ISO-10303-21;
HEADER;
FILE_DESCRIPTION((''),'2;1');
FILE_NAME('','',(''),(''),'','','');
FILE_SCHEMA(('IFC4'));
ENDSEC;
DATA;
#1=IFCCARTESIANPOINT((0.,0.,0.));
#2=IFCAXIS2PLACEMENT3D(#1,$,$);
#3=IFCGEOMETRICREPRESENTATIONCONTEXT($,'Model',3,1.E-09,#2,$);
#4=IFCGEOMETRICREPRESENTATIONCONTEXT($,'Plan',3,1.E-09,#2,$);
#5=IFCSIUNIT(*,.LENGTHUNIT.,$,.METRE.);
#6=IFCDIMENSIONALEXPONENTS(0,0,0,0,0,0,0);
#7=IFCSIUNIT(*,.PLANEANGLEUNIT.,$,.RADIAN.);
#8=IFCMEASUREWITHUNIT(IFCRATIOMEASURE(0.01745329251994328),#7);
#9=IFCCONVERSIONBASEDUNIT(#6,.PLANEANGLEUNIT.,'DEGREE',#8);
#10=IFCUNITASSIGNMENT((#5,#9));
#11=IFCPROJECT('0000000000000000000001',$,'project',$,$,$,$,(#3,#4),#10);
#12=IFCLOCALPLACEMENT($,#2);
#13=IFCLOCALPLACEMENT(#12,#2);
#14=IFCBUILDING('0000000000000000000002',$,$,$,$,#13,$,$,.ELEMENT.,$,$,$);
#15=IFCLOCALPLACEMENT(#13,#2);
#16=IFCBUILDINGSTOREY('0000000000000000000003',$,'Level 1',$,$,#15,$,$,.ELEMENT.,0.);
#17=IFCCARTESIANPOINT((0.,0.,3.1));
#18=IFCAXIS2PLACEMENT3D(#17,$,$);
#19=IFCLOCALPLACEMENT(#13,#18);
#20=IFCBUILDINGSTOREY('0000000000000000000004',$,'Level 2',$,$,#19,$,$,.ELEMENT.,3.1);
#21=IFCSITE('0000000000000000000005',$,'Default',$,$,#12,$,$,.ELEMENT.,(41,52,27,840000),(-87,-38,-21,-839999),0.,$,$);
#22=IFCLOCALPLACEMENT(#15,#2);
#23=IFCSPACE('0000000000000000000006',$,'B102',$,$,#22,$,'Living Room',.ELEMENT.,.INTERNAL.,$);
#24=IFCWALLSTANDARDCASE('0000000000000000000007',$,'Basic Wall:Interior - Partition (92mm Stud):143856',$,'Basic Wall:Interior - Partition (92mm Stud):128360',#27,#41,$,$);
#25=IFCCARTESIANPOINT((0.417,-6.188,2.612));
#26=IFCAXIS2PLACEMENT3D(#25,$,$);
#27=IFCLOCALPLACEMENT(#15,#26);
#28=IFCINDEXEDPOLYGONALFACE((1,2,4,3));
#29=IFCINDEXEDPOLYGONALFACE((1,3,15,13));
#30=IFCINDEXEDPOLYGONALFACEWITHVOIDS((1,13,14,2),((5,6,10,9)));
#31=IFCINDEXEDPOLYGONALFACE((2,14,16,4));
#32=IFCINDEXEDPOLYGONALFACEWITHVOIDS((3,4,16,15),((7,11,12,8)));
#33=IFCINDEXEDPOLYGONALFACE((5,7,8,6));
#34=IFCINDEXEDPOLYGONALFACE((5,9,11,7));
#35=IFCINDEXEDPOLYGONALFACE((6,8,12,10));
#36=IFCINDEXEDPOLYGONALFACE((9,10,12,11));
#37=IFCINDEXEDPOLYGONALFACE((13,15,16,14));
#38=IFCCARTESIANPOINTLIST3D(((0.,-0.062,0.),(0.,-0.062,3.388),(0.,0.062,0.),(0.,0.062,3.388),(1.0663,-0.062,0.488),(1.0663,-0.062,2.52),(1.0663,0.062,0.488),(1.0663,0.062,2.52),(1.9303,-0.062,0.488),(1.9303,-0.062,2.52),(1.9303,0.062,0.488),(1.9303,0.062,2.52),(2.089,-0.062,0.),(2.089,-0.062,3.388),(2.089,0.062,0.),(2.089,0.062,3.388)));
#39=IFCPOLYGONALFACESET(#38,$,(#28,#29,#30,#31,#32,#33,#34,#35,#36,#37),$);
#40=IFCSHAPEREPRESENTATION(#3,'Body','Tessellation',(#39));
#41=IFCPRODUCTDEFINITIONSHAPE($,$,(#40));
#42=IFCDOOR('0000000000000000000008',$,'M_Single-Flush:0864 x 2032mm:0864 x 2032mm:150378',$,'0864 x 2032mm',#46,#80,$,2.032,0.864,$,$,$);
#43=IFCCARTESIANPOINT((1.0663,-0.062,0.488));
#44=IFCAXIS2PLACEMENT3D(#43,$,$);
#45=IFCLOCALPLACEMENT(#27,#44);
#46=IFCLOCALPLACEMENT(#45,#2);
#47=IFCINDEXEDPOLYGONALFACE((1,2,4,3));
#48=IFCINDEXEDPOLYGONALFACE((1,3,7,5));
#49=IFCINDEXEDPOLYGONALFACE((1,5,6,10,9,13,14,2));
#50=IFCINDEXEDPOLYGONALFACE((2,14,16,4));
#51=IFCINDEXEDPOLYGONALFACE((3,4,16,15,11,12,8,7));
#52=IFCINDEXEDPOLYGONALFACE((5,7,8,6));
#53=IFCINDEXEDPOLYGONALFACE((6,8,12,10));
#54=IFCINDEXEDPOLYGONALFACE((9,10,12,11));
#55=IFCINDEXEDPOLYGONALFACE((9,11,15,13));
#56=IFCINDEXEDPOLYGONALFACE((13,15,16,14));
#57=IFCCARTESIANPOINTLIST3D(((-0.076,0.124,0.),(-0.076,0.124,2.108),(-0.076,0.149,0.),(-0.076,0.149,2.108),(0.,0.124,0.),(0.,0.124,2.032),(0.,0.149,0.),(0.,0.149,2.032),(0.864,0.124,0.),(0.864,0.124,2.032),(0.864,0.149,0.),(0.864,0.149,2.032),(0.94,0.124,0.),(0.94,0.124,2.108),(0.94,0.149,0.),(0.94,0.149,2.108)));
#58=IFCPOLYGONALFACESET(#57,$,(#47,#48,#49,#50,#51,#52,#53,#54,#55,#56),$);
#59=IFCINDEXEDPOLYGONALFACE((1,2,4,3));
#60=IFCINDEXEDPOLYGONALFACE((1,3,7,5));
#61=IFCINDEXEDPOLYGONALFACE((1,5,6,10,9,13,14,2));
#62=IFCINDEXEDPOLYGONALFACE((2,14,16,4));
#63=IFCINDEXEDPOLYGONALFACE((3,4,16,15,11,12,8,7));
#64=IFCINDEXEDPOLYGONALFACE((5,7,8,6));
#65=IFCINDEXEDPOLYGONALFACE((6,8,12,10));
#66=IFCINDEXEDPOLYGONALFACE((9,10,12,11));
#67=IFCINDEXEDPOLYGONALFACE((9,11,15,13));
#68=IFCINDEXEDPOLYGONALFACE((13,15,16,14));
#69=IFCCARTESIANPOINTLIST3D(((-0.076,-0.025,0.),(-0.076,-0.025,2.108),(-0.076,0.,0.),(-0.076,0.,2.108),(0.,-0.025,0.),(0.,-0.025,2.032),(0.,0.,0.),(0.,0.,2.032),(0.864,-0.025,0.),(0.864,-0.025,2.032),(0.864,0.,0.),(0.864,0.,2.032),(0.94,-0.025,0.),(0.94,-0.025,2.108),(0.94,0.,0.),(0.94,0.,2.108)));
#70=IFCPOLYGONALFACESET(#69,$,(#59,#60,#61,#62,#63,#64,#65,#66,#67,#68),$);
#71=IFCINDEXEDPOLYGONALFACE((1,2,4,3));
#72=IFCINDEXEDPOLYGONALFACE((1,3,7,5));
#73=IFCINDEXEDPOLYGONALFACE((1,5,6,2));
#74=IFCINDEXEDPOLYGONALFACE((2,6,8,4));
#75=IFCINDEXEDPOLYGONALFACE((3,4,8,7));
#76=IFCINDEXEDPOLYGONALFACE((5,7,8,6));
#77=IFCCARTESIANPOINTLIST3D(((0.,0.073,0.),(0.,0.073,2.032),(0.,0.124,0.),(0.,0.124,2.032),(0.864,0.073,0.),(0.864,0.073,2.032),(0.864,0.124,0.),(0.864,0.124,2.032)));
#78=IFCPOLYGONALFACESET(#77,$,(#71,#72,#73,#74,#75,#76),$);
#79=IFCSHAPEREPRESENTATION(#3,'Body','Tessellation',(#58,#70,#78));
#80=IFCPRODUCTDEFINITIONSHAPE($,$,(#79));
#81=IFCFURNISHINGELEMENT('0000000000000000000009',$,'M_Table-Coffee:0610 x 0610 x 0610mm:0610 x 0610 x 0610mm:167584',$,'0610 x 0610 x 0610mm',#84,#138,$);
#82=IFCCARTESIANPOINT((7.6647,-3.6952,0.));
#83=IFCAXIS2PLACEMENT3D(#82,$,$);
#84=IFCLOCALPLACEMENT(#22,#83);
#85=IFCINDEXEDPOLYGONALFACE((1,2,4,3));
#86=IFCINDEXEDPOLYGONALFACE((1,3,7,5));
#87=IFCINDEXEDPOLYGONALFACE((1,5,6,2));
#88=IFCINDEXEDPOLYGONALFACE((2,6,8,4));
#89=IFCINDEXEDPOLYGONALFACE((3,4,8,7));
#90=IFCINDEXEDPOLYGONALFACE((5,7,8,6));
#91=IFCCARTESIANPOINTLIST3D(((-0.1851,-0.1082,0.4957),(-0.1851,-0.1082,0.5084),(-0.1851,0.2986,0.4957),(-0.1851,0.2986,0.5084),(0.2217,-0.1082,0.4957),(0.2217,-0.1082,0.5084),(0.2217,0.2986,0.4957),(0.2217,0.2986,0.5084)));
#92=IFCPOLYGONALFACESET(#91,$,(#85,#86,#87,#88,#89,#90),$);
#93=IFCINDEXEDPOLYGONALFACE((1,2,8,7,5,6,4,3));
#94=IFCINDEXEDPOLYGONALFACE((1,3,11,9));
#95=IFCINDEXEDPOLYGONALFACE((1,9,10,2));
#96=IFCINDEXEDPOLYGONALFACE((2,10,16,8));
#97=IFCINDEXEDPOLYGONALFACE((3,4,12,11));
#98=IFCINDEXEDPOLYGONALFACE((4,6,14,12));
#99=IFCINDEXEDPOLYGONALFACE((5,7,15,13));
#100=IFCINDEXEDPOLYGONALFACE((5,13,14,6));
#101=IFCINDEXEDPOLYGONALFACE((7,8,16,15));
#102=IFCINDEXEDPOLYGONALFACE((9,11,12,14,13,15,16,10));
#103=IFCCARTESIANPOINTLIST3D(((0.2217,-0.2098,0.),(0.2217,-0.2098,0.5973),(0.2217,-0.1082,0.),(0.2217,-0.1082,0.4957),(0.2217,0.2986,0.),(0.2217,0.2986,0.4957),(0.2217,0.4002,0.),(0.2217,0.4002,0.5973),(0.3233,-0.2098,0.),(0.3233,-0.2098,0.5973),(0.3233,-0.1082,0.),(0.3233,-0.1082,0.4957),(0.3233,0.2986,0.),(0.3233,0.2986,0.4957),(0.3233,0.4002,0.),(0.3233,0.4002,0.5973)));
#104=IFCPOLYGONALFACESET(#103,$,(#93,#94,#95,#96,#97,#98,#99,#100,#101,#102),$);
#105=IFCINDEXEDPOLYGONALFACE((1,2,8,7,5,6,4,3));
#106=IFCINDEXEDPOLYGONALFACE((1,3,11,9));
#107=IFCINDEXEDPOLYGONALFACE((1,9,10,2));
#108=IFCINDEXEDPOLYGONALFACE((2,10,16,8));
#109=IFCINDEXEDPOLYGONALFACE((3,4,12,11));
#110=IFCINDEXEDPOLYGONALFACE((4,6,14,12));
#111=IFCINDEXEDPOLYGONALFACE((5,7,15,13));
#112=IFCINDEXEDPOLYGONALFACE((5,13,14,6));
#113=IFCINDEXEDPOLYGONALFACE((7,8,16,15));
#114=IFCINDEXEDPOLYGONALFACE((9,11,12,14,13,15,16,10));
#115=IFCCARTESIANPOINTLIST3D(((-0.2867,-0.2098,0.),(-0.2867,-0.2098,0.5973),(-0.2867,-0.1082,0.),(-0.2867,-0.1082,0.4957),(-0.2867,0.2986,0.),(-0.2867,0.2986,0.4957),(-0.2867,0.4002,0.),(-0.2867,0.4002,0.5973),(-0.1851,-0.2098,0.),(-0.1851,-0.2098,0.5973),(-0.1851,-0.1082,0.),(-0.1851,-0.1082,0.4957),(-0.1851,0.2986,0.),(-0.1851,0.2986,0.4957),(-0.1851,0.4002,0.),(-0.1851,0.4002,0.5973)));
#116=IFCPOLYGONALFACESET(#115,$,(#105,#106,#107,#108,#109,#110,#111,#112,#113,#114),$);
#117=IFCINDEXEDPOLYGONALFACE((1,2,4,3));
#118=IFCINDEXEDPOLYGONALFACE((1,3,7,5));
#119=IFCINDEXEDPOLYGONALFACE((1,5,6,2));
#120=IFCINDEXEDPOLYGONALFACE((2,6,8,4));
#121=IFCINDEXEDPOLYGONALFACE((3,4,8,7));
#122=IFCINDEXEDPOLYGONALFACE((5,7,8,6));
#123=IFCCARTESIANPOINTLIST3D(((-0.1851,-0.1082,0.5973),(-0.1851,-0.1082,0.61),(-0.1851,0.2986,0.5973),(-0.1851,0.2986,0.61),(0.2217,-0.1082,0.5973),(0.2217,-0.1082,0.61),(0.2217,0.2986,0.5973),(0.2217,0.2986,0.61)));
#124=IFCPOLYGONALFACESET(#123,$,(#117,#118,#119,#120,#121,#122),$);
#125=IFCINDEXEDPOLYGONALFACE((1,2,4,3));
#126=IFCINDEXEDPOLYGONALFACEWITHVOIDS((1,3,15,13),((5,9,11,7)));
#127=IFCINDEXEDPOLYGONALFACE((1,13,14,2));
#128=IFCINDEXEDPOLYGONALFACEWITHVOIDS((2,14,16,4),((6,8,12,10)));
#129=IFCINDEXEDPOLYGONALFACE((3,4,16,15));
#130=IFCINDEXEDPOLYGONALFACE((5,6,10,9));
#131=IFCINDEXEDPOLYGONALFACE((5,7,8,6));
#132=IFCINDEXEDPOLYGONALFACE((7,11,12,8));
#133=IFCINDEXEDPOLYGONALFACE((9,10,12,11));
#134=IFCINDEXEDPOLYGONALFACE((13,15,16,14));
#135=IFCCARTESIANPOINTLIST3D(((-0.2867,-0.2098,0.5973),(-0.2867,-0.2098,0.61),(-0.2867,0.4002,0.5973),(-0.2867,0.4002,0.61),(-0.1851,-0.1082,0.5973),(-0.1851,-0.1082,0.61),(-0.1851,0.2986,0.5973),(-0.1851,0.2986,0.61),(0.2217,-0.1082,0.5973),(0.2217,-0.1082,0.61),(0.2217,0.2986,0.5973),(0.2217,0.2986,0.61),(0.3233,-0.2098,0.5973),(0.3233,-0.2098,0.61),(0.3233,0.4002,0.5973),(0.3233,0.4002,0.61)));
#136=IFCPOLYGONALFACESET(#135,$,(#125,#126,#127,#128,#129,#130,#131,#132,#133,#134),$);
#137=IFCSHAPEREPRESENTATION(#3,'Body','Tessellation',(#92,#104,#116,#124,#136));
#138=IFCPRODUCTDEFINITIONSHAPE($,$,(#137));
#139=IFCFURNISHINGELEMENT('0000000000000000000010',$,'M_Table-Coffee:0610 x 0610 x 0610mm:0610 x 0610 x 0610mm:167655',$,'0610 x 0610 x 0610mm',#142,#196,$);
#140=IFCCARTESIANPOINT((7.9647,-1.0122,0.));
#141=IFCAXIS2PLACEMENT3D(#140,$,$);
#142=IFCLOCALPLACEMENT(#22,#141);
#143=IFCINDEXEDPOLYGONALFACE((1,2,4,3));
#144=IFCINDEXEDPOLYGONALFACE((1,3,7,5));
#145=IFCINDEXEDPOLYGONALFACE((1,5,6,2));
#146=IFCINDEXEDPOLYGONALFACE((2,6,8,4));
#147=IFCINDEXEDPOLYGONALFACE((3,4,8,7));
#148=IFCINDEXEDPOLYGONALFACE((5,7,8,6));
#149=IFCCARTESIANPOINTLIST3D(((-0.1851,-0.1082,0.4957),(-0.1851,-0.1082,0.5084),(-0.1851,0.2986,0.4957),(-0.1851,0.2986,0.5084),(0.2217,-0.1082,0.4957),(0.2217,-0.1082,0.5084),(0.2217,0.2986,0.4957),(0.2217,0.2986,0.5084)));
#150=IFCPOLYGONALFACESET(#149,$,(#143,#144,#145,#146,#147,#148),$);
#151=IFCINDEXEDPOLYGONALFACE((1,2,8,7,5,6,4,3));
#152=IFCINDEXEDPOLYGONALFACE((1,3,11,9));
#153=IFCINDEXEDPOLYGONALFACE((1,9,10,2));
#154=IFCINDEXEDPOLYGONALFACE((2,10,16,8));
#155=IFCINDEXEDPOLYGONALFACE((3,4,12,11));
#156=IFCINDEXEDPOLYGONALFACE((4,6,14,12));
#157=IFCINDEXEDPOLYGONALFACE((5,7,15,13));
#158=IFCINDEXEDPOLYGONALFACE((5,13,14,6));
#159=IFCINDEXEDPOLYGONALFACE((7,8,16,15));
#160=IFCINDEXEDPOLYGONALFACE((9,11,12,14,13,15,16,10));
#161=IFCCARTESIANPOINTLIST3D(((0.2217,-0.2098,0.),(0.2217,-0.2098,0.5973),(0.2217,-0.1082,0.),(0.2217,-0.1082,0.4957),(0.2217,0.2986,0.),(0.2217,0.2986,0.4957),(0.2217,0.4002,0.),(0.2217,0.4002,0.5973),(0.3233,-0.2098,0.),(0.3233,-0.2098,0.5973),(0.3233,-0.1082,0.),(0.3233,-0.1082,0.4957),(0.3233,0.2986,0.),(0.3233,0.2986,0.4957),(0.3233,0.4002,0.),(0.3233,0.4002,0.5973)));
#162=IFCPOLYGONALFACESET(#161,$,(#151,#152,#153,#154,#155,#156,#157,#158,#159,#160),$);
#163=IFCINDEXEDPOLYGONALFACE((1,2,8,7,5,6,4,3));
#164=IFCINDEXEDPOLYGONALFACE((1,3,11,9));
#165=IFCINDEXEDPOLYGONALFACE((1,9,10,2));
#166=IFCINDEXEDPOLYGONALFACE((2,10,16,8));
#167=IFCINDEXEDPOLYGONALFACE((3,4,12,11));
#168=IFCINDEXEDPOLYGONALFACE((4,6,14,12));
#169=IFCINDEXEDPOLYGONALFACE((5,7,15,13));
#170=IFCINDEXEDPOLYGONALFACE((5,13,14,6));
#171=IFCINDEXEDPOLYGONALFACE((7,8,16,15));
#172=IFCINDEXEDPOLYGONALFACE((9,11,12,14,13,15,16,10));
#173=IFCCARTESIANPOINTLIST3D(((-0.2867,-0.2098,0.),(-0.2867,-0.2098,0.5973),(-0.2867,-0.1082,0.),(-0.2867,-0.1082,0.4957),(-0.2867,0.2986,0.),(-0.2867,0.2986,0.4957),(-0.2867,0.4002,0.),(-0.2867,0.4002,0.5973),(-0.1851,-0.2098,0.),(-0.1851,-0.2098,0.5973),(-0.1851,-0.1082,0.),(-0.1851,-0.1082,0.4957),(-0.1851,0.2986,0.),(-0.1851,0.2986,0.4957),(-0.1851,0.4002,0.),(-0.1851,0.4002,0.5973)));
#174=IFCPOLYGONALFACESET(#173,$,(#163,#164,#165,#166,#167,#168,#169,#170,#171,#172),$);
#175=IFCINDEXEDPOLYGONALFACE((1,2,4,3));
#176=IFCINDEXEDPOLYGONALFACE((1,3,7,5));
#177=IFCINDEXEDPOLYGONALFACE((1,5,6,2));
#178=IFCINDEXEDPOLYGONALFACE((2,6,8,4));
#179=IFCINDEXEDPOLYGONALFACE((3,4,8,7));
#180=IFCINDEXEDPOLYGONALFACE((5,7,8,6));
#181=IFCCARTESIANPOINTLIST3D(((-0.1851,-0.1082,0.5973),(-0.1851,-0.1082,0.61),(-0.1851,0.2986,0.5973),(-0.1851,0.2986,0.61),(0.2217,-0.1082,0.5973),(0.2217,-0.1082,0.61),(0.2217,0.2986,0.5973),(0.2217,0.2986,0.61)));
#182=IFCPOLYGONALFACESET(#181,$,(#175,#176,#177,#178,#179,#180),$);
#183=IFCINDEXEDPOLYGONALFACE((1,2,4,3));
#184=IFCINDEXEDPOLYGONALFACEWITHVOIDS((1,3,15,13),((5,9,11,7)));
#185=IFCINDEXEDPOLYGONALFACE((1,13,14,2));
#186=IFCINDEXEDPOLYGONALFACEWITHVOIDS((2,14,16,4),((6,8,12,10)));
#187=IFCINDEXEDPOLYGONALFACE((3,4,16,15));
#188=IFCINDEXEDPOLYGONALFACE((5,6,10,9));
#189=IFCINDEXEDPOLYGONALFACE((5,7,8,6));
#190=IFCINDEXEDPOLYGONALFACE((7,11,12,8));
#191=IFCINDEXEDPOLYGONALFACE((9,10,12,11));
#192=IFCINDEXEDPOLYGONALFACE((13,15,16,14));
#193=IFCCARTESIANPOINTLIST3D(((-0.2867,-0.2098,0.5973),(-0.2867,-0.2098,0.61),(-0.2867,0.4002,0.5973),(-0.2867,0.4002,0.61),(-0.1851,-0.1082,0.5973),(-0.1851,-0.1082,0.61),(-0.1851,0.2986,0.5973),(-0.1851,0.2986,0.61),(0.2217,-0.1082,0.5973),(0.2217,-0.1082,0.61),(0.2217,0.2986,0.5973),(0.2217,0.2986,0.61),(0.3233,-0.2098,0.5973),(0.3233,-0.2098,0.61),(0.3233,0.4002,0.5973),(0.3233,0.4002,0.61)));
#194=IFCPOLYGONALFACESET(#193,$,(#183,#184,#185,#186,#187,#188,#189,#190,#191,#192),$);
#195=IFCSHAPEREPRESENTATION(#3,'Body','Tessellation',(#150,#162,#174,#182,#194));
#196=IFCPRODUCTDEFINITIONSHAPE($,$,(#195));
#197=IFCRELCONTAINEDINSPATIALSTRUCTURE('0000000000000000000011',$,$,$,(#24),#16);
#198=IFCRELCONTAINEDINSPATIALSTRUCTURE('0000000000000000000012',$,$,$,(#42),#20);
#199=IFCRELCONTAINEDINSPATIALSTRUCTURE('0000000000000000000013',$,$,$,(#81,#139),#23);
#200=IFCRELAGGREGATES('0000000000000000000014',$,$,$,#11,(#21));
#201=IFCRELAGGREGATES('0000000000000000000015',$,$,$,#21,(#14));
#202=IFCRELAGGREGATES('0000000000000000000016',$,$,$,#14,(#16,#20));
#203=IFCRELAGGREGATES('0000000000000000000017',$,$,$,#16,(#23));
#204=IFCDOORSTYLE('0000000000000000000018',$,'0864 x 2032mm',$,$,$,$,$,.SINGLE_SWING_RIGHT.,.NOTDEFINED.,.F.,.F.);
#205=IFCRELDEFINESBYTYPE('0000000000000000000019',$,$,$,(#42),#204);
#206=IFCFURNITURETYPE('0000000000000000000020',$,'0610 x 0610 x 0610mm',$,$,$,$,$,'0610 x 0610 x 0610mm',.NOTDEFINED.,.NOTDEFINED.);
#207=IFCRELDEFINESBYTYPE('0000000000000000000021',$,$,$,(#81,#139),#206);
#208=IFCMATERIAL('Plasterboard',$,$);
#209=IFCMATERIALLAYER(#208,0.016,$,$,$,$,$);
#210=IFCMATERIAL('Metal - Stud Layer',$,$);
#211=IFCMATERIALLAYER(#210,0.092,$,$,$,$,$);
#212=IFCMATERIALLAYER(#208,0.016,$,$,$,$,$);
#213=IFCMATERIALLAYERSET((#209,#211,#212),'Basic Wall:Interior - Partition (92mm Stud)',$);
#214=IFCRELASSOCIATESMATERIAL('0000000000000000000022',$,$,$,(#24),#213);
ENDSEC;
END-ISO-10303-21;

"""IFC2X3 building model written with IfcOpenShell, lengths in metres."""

from ifc_helpers import new_model, entity, si_unit, converted_unit, frame, frame_2d, origin, origin_2d_with_axis, place, context, project, spatial, polyline, rectangle, outline, extrude, source, transform, mapped, material, layer, layer_set, layer_usage, type_object, type_shapes, element, fill, save


model = new_model("IFC2X3")

# Units and contexts
model_context = context("Model", 3, precision=1e-09, world=origin())
plan_context = context("Plan", 3, precision=1e-09, world=origin())
ifc_project = project(units=[si_unit("LENGTHUNIT", "METRE"), converted_unit("PLANEANGLEUNIT", "DEGREE", entity("IfcRatioMeasure", 0.01745329251994328), si_unit("PLANEANGLEUNIT", "RADIAN"), dimensions=[0, 0, 0, 0, 0, 0, 0])], contexts=[model_context, plan_context])

# Site, building, storey
site_placement = place(None, origin())
site = spatial("IfcSite", under=ifc_project, at=site_placement, Name="Default", CompositionType="ELEMENT", RefLatitude=(41, 52, 27, 840000), RefLongitude=(-87, -38, -21, -839999), RefElevation=0.0)
building_placement = place(site_placement, origin())
building = spatial("IfcBuilding", under=site, at=building_placement, CompositionType="ELEMENT")
storey_1_placement = place(building_placement, origin())
storey_1 = spatial("IfcBuildingStorey", under=building, at=storey_1_placement, Name="Level 1", CompositionType="ELEMENT", Elevation=0.0)

# Shared definitions
ifc_material_1 = material(Name="Metal - Stud Layer")
ifc_material_2 = material(Name="Plasterboard")

# Shared definitions
ifc_layer_1 = layer(ifc_material_2, 0.016)
ifc_layer_2 = layer(ifc_material_1, 0.092)
ifc_layer_3 = layer(ifc_material_2, 0.016)
ifc_layer_set_1 = layer_set([ifc_layer_1, ifc_layer_2, ifc_layer_3], Name="Basic Wall:Interior - Partition (92mm Stud)")

# Wall, opening
ifc_layer_usage_1 = layer_usage(ifc_layer_set_1, "AXIS2", "NEGATIVE", 0.062)
wall_1_placement = place(storey_1_placement, frame((0.417, -6.188, 2.612)))
wall_1 = element("IfcWallStandardCase", 1, at=wall_1_placement, inside=storey_1, material=ifc_layer_usage_1, Name="Basic Wall:Interior - Partition (92mm Stud):143856", ObjectType="Basic Wall:Interior - Partition (92mm Stud):128360", context=model_context, shape_type="SweptSolid", body=[
    extrude(rectangle(XDim=2.089, YDim=0.124, at=frame_2d((1.0445, 0.0), x_axis=(-1.0, 0.0))), origin(), (0.0, 0.0, 1.0), 3.388),
])
opening_1_placement = place(wall_1_placement, frame((1.0663, -0.062, 0.488)))
opening_1 = element("IfcOpeningElement", 2, at=opening_1_placement, cuts=wall_1, ObjectType="Opening", context=model_context, shape_type="SweptSolid", body=[
    extrude(rectangle(XDim=0.864, YDim=2.032, at=frame_2d((1.016, 0.432), x_axis=(0.0, 1.0))), frame((0.0, 0.0, 0.0), z_axis=(0.0, 1.0, 0.0), x_axis=(0.0, 0.0, 1.0)), (0.0, 0.0, 1.0), 0.124),
])

# Shared definitions
storey_2_placement = place(building_placement, frame((0.0, 0.0, 3.1)))
storey_2 = spatial("IfcBuildingStorey", under=building, at=storey_2_placement, Name="Level 2", CompositionType="ELEMENT", Elevation=3.1)

# Door
door_style_1 = type_object("IfcDoorStyle", Name="0864 x 2032mm", ConstructionType="NOTDEFINED", OperationType="SINGLE_SWING_RIGHT", ParameterTakesPrecedence=False, Sizeable=False)
shared_shape_1 = source(origin(), model_context, "Body", "SweptSolid", [
    extrude(outline(polyline([(-0.508, -1.073), (0.508, -1.073), (0.508, 1.035), (0.432, 1.035), (0.432, -0.997), (-0.432, -0.997), (-0.432, 1.035), (-0.508, 1.035), (-0.508, -1.073)])), frame((0.432, 0.124, 1.035), z_axis=(0.0, 1.0, 0.0), x_axis=(1.0, 0.0, 0.0)), (0.0, 0.0, 1.0), 0.025),
    extrude(outline(polyline([(-1.073, -0.508), (1.035, -0.508), (1.035, -0.432), (-0.997, -0.432), (-0.997, 0.432), (1.035, 0.432), (1.035, 0.508), (-1.073, 0.508), (-1.073, -0.508)])), frame((0.432, -0.025, 1.035), z_axis=(0.0, 1.0, 0.0), x_axis=(0.0, 0.0, -1.0)), (0.0, 0.0, 1.0), 0.025),
    extrude(rectangle(XDim=0.051, YDim=0.864, at=origin_2d_with_axis()), frame((0.432, 0.0985, 0.0), z_axis=(0.0, 0.0, 1.0), x_axis=(0.0, 1.0, 0.0)), (0.0, 0.0, 1.0), 2.032),
])
type_shapes(door_style_1, [shared_shape_1])
door_1_placement = place(opening_1_placement, origin())
door_1 = element("IfcDoor", 3, at=door_1_placement, inside=storey_2, type_object=door_style_1, Name="M_Single-Flush:0864 x 2032mm:0864 x 2032mm:150378", ObjectType="0864 x 2032mm", OverallHeight=2.032, OverallWidth=0.864, context=model_context, shape_type="MappedRepresentation", body=[
    mapped(shared_shape_1, transform((0.0, 0.0, 0.0), scale=1.0)),
])
fill(opening_1, door_1)

# Shared definitions
space_1_placement = place(storey_1_placement, origin())
space_1 = spatial("IfcSpace", under=storey_1, at=space_1_placement, Name="B102", LongName="Living Room", CompositionType="ELEMENT", InteriorOrExteriorSpace="INTERNAL")

# Furnishing elements
furniture_type_1 = type_object("IfcFurnitureType", Name="0610 x 0610 x 0610mm", ElementType="0610 x 0610 x 0610mm", AssemblyPlace="NOTDEFINED")
shared_shape_2 = source(origin(), model_context, "Body", "SweptSolid", [
    extrude(rectangle(XDim=0.4068, YDim=0.4068, at=origin_2d_with_axis()), frame((0.0183, 0.0952, 0.4957), z_axis=(0.0, 0.0, 1.0), x_axis=(-1.0, 0.0, 0.0)), (0.0, 0.0, 1.0), 0.0127),
    extrude(outline(polyline([(-0.2732, -0.305), (0.324, -0.305), (0.324, 0.305), (-0.2732, 0.305), (-0.2732, 0.2034), (0.2225, 0.2034), (0.2225, -0.2034), (-0.2732, -0.2034), (-0.2732, -0.305)])), frame((0.2217, 0.0952, 0.2732), z_axis=(1.0, 0.0, 0.0), x_axis=(0.0, 0.0, 1.0)), (0.0, 0.0, 1.0), 0.1016),
    extrude(outline(polyline([(-0.305, -0.3241), (0.305, -0.3241), (0.305, 0.2733), (0.2034, 0.2733), (0.2034, -0.2224), (-0.2034, -0.2224), (-0.2034, 0.2733), (-0.305, 0.2733), (-0.305, -0.3241)])), frame((-0.2867, 0.0952, 0.2733), z_axis=(1.0, 0.0, 0.0), x_axis=(0.0, -1.0, 0.0)), (0.0, 0.0, 1.0), 0.1016),
    extrude(rectangle(XDim=0.4068, YDim=0.4068, at=origin_2d_with_axis()), frame((0.0183, 0.0952, 0.5973), z_axis=(0.0, 0.0, 1.0), x_axis=(-1.0, 0.0, 0.0)), (0.0, 0.0, 1.0), 0.0127),
    extrude(outline(polyline([(-0.305, -0.305), (0.305, -0.305), (0.305, 0.305), (-0.305, 0.305), (-0.305, -0.305)]), holes=[polyline([(-0.2034, -0.2034), (-0.2034, 0.2034), (0.2034, 0.2034), (0.2034, -0.2034), (-0.2034, -0.2034)])]), frame((0.0183, 0.0952, 0.5973), z_axis=(0.0, 0.0, 1.0), x_axis=(-1.0, 0.0, 0.0)), (0.0, 0.0, 1.0), 0.0127),
])
type_shapes(furniture_type_1, [shared_shape_2])
for number, where, name in (
    (4, (7.6647, -3.6952, 0.0), "M_Table-Coffee:0610 x 0610 x 0610mm:0610 x 0610 x 0610mm:167584"),
    (5, (7.9647, -1.0122, 0.0), "M_Table-Coffee:0610 x 0610 x 0610mm:0610 x 0610 x 0610mm:167655"),
):
    element("IfcFurnishingElement", number, at=place(space_1_placement, frame(where)), inside=space_1, type_object=furniture_type_1, Name=name, ObjectType="0610 x 0610 x 0610mm", context=model_context, shape_type="MappedRepresentation", body=[
        mapped(shared_shape_2, transform((0.0, 0.0, 0.0), scale=1.0)),
    ])

save(model, "model.ifc")
